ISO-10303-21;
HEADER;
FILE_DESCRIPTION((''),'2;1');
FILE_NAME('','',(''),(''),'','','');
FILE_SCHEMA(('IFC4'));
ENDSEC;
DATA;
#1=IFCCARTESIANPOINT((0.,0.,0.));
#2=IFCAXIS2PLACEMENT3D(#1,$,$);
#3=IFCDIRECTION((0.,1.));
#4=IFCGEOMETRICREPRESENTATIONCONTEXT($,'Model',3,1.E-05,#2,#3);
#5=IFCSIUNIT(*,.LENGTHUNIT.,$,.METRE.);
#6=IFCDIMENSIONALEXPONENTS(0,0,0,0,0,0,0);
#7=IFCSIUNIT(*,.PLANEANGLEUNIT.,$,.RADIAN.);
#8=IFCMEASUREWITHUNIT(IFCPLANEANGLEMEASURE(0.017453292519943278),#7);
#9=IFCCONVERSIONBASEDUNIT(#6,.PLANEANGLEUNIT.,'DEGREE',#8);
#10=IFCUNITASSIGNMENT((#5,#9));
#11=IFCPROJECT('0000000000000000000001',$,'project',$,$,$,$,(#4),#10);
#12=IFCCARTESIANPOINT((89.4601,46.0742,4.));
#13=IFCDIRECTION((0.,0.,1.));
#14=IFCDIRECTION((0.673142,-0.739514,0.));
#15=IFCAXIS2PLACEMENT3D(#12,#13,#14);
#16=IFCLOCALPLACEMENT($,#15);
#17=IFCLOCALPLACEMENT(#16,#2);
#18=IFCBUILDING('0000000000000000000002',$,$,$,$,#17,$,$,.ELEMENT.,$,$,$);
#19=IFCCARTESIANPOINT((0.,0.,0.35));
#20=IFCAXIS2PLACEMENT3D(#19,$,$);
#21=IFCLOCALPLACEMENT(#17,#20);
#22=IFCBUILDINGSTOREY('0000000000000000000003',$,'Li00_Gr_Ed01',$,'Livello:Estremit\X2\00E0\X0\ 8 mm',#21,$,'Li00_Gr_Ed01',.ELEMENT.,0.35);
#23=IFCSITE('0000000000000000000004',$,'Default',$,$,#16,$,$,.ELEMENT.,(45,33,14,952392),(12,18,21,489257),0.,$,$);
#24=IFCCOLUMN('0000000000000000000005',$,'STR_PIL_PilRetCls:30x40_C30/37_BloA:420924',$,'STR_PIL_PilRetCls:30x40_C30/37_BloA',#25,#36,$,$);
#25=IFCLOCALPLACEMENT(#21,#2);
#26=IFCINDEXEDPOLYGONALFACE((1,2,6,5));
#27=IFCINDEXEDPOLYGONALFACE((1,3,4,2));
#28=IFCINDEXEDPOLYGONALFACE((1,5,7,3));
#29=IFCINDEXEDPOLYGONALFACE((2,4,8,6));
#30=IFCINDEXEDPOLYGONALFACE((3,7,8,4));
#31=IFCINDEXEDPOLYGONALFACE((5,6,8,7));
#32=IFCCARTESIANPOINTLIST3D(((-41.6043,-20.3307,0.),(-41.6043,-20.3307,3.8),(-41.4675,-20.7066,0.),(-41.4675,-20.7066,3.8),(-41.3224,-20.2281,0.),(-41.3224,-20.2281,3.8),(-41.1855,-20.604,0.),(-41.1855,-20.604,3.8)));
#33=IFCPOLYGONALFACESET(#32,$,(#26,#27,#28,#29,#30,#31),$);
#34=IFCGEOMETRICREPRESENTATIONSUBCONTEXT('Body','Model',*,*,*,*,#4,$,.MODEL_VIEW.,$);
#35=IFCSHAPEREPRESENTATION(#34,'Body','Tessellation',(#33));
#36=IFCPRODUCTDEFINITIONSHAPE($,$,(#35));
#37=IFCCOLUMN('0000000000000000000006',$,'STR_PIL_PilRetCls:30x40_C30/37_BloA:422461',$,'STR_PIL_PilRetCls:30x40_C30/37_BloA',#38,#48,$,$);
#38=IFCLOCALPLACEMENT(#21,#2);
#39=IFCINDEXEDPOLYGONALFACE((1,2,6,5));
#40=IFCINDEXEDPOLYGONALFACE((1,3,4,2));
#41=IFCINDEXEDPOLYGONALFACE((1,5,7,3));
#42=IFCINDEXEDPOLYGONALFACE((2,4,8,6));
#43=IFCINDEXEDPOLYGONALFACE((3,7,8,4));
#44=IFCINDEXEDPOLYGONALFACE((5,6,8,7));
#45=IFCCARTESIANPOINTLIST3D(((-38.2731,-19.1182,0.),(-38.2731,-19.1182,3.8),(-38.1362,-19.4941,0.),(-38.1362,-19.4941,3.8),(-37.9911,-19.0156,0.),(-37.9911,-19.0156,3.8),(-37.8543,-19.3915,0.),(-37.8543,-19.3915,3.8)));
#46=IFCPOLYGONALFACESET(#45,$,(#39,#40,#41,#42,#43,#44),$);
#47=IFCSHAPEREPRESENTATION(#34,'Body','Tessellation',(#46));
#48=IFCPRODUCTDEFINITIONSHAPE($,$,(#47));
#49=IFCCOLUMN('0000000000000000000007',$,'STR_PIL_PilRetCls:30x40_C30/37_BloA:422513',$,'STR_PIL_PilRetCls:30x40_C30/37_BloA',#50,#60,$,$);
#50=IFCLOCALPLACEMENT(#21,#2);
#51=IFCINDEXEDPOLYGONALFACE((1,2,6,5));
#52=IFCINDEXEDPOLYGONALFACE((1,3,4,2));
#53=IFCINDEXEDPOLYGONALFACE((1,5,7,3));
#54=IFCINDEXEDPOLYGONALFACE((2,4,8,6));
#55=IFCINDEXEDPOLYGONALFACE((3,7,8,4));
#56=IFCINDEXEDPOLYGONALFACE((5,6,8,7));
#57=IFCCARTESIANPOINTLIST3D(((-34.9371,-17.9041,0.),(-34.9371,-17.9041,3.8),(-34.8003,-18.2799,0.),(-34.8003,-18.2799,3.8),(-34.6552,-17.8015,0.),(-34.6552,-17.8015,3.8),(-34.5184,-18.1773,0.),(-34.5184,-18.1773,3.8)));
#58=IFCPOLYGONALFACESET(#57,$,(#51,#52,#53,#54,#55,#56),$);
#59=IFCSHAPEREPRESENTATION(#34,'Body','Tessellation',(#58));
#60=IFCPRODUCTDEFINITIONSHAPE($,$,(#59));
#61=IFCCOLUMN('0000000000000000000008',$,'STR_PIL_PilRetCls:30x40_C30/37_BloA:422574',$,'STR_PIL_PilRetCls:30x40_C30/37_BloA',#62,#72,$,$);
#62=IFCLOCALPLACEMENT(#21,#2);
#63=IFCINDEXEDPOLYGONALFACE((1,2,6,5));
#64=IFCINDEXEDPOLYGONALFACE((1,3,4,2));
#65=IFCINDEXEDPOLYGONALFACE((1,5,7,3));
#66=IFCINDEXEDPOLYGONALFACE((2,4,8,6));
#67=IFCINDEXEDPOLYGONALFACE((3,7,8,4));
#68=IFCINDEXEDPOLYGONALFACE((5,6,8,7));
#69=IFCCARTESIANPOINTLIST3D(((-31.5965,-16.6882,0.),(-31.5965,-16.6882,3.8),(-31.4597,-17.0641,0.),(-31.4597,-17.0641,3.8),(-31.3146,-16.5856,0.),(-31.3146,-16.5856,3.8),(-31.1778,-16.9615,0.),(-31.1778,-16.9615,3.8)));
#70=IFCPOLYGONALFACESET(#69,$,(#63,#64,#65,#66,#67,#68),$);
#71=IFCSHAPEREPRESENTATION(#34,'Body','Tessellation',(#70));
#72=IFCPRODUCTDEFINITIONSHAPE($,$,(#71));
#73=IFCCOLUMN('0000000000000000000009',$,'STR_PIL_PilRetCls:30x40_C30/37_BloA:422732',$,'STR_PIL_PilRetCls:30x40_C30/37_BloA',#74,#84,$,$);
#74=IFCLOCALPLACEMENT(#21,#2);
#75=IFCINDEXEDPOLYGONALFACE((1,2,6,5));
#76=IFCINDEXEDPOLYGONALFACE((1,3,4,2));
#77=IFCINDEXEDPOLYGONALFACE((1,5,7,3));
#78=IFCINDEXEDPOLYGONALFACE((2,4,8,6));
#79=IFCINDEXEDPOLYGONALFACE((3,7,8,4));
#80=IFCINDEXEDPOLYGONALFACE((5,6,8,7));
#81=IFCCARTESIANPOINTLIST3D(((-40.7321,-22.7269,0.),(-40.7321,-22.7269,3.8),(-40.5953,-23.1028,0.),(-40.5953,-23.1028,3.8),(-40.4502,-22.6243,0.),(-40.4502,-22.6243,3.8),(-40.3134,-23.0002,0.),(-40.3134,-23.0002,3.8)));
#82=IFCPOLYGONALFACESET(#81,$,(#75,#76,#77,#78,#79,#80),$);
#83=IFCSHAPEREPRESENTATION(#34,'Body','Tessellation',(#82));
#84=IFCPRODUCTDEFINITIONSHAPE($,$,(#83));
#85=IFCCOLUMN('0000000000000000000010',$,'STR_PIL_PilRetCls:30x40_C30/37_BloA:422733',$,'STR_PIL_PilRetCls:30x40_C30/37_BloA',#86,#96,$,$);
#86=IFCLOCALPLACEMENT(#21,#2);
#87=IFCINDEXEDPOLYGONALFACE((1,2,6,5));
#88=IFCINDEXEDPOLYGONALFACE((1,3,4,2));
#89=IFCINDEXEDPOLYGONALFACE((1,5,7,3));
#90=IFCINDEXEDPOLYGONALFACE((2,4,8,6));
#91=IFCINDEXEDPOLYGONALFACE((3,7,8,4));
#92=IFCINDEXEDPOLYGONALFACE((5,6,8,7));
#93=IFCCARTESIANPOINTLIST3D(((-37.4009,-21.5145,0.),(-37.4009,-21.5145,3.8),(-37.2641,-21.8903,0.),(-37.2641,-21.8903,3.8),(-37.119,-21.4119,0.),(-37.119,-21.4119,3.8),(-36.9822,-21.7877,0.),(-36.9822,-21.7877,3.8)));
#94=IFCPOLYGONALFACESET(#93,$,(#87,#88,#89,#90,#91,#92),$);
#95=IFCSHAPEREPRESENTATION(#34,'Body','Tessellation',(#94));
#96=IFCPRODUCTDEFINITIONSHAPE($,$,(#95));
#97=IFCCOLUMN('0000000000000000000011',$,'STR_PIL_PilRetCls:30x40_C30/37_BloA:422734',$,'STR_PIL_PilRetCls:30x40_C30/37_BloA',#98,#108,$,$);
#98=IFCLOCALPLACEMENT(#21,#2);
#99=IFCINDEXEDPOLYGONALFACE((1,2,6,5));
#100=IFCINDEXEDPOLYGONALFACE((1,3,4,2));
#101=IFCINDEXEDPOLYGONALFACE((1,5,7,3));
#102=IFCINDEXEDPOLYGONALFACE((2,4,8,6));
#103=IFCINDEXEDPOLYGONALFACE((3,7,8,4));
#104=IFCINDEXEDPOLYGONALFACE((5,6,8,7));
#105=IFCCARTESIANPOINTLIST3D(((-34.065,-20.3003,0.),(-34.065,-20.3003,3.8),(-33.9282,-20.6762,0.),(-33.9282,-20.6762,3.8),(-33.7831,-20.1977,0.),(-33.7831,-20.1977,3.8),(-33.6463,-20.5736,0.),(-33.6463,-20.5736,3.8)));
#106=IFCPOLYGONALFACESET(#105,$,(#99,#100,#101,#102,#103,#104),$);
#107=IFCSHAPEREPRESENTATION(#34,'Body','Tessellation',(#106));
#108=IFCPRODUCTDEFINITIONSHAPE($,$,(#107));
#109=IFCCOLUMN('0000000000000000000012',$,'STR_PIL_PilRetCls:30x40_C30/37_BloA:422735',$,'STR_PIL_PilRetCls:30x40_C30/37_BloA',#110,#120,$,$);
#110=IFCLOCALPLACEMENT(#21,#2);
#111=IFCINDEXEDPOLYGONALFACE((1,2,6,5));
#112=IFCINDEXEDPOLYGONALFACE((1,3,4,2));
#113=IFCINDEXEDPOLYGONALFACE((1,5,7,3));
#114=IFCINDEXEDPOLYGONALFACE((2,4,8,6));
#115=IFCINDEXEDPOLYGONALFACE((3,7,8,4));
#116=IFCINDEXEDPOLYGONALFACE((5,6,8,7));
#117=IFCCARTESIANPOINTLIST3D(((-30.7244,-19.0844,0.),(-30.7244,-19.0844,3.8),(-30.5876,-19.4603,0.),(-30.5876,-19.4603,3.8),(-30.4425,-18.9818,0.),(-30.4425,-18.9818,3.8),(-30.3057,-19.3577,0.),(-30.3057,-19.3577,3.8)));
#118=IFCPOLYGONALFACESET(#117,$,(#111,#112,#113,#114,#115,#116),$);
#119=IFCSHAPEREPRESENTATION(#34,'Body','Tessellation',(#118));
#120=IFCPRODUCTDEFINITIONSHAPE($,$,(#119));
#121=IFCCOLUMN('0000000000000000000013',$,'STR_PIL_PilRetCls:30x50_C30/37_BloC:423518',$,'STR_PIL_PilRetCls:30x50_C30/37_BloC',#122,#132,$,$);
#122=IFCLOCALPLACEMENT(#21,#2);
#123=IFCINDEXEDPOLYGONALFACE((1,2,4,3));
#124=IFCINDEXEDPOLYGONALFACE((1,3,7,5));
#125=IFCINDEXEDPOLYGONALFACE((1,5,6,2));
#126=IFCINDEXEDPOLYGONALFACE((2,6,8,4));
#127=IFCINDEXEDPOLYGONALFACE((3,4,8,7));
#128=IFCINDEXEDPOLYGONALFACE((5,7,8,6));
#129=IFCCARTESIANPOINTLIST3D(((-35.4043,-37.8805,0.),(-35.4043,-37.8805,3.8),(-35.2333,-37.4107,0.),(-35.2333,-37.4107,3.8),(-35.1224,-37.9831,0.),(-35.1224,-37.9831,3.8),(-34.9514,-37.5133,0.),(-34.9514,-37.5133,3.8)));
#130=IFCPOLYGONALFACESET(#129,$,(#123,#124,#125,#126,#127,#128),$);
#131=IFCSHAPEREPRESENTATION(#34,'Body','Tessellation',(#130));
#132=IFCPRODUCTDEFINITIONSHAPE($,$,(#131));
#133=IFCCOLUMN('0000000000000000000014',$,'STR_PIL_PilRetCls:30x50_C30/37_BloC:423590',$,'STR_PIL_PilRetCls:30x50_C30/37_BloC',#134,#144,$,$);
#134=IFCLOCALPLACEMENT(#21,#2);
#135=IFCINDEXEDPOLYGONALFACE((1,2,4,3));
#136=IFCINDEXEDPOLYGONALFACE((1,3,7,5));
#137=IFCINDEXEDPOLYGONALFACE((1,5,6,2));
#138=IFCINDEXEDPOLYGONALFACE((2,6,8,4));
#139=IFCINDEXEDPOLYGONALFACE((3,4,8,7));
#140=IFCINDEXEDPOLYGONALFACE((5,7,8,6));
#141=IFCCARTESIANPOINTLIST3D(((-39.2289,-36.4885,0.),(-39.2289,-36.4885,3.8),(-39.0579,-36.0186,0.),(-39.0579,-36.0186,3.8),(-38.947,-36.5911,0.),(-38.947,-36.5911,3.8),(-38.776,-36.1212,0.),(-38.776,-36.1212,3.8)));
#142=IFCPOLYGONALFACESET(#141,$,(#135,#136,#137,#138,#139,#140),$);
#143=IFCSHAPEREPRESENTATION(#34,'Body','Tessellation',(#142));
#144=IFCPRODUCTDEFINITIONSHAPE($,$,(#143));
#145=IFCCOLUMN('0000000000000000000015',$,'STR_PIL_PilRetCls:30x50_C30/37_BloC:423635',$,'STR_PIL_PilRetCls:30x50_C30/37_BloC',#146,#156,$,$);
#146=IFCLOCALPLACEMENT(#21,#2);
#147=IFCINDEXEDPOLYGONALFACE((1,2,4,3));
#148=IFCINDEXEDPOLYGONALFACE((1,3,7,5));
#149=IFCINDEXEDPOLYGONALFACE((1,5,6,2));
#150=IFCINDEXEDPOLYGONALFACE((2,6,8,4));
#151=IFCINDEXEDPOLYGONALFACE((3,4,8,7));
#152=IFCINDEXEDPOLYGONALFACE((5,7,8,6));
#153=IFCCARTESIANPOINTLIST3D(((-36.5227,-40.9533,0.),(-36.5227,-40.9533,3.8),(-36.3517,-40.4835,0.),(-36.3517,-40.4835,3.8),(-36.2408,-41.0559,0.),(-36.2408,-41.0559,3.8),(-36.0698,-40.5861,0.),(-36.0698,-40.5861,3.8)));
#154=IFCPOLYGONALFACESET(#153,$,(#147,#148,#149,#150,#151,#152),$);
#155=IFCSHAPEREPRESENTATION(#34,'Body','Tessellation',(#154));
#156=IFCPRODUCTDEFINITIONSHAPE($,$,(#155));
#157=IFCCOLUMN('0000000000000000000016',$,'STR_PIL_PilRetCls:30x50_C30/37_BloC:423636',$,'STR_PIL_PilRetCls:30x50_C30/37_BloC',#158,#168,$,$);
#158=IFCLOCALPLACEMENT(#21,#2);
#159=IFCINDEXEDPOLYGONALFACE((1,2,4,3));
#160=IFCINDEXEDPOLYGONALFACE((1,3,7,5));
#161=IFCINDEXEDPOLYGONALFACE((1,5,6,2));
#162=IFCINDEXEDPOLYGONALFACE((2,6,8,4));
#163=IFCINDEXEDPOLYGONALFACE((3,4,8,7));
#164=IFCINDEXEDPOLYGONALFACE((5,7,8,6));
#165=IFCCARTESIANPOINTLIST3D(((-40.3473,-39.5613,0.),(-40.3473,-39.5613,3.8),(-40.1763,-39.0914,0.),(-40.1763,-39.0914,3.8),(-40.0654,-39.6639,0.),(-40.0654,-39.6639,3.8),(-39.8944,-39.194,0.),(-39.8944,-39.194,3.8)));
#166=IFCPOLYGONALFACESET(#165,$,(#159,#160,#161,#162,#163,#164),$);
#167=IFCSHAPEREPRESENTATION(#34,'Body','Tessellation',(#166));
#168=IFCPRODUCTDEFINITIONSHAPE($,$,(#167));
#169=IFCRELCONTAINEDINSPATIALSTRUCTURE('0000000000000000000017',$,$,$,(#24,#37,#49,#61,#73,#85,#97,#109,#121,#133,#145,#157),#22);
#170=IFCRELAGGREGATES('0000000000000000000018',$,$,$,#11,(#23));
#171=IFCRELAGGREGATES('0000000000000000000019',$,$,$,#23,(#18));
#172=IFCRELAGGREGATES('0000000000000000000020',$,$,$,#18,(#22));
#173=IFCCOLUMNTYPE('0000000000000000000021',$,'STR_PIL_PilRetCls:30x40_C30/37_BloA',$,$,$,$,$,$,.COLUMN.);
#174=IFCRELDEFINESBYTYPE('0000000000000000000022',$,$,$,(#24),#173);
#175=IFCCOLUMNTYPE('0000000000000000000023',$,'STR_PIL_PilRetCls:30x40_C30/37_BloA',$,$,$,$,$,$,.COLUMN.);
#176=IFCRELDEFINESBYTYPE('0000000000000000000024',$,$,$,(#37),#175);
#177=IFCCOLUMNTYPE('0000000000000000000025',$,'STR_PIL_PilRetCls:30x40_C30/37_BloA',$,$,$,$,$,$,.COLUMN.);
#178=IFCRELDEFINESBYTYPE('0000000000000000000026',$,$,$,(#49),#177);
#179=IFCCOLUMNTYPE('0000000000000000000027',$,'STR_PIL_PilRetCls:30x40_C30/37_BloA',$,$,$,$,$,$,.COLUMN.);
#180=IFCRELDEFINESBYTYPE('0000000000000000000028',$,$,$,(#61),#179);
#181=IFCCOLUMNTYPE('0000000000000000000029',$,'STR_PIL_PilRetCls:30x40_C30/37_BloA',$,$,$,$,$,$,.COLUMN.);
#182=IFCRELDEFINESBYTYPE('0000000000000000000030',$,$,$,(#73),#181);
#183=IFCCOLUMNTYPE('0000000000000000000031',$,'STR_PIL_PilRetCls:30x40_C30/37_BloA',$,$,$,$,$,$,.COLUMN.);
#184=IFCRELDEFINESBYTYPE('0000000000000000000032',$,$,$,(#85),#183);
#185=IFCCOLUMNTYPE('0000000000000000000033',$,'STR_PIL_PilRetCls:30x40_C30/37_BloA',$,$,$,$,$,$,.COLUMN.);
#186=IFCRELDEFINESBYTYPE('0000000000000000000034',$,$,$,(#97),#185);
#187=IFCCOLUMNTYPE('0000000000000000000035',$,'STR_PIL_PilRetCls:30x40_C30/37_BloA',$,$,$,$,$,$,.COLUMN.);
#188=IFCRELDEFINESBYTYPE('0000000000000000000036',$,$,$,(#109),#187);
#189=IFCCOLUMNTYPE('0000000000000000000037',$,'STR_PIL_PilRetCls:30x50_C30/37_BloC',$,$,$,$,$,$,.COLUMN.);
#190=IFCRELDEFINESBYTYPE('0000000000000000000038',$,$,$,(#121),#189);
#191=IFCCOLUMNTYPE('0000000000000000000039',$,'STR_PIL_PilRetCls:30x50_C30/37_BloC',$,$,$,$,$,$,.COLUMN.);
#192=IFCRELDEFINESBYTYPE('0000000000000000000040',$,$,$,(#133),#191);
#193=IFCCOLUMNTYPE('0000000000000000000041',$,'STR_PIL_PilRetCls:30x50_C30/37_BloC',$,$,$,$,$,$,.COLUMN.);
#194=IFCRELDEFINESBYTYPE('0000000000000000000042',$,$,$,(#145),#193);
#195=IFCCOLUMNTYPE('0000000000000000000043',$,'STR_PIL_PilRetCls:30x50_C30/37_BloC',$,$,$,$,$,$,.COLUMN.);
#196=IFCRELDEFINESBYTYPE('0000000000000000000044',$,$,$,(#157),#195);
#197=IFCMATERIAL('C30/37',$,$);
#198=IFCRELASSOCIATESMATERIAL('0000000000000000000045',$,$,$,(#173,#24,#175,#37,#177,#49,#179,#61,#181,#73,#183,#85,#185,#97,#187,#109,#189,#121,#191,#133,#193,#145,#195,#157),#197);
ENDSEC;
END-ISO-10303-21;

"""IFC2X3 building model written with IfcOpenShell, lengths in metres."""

from ifc_helpers import new_model, entity, si_unit, converted_unit, direction, frame, frame_2d, origin, place, context, subcontext, project, spatial, rectangle, extrude, source, transform, mapped, material, type_object, type_shapes, element, save


model = new_model("IFC2X3")

# Units and contexts
model_context = context("Model", 3, precision=1e-05, world=origin(), true_north=direction((0.0, 1.0)))
body_context = subcontext(model_context, "Body", "Model", "MODEL_VIEW")
ifc_project = project(units=[si_unit("LENGTHUNIT", "METRE"), converted_unit("PLANEANGLEUNIT", "DEGREE", entity("IfcPlaneAngleMeasure", 0.017453292519943278), si_unit("PLANEANGLEUNIT", "RADIAN"), dimensions=[0, 0, 0, 0, 0, 0, 0])], contexts=[model_context])

# Site, building, storey
site_placement = place(None, frame((89.4601, 46.0742, 4.0), z_axis=(0.0, 0.0, 1.0), x_axis=(0.673142, -0.739514, 0.0)))
site = spatial("IfcSite", under=ifc_project, at=site_placement, Name="Default", CompositionType="ELEMENT", RefLatitude=(45, 33, 14, 952392), RefLongitude=(12, 18, 21, 489257), RefElevation=0.0)
building_placement = place(site_placement, origin())
building = spatial("IfcBuilding", under=site, at=building_placement, CompositionType="ELEMENT")
storey_placement = place(building_placement, frame((0.0, 0.0, 0.35)))
storey = spatial("IfcBuildingStorey", under=building, at=storey_placement, Name="Li00_Gr_Ed01", ObjectType="Livello:Estremità 8 mm", LongName="Li00_Gr_Ed01", CompositionType="ELEMENT", Elevation=0.35)

# Columns
ifc_material_1 = material(Name="C30/37")
column_type_1 = type_object("IfcColumnType", Name="STR_PIL_PilRetCls:30x40_C30/37_BloA", PredefinedType="COLUMN", material=ifc_material_1)
shared_shape_1 = source(origin(), body_context, "Body", "SweptSolid", [
    extrude(rectangle(XDim=0.3, YDim=0.4, at=frame_2d((0.0, 0.0), x_axis=(1.0, 0.0))), frame((-41.3949, -20.4673, 0.35), z_axis=(0.0, 0.0, 1.0), x_axis=(0.939693, 0.34202, 0.0)), (0.0, 0.0, 1.0), 3.8),
])
type_shapes(column_type_1, [shared_shape_1])
column_1_placement = place(storey_placement, frame((0.0, 0.0, -0.35)))
element("IfcColumn", 1, at=column_1_placement, inside=storey, type_object=column_type_1, material=ifc_material_1, Name="STR_PIL_PilRetCls:30x40_C30/37_BloA:420924", ObjectType="STR_PIL_PilRetCls:30x40_C30/37_BloA", context=body_context, shape_type="MappedRepresentation", body=[
    mapped(shared_shape_1, transform((0.0, 0.0, 0.0), scale=1.0)),
])
column_type_2 = type_object("IfcColumnType", Name="STR_PIL_PilRetCls:30x40_C30/37_BloA", PredefinedType="COLUMN", material=ifc_material_1)
shared_shape_2 = source(origin(), body_context, "Body", "SweptSolid", [
    extrude(rectangle(XDim=0.3, YDim=0.4, at=frame_2d((0.0, 0.0), x_axis=(1.0, 0.0))), frame((-38.0637, -19.2549, 0.35), z_axis=(0.0, 0.0, 1.0), x_axis=(0.939693, 0.34202, 0.0)), (0.0, 0.0, 1.0), 3.8),
])
type_shapes(column_type_2, [shared_shape_2])
column_2_placement = place(storey_placement, frame((0.0, 0.0, -0.35)))
element("IfcColumn", 2, at=column_2_placement, inside=storey, type_object=column_type_2, material=ifc_material_1, Name="STR_PIL_PilRetCls:30x40_C30/37_BloA:422461", ObjectType="STR_PIL_PilRetCls:30x40_C30/37_BloA", context=body_context, shape_type="MappedRepresentation", body=[
    mapped(shared_shape_2, transform((0.0, 0.0, 0.0), scale=1.0)),
])
column_type_3 = type_object("IfcColumnType", Name="STR_PIL_PilRetCls:30x40_C30/37_BloA", PredefinedType="COLUMN", material=ifc_material_1)
shared_shape_3 = source(origin(), body_context, "Body", "SweptSolid", [
    extrude(rectangle(XDim=0.3, YDim=0.4, at=frame_2d((0.0, 0.0), x_axis=(1.0, 0.0))), frame((-34.7278, -18.0407, 0.35), z_axis=(0.0, 0.0, 1.0), x_axis=(0.939693, 0.34202, 0.0)), (0.0, 0.0, 1.0), 3.8),
])
type_shapes(column_type_3, [shared_shape_3])
column_3_placement = place(storey_placement, frame((0.0, 0.0, -0.35)))
element("IfcColumn", 3, at=column_3_placement, inside=storey, type_object=column_type_3, material=ifc_material_1, Name="STR_PIL_PilRetCls:30x40_C30/37_BloA:422513", ObjectType="STR_PIL_PilRetCls:30x40_C30/37_BloA", context=body_context, shape_type="MappedRepresentation", body=[
    mapped(shared_shape_3, transform((0.0, 0.0, 0.0), scale=1.0)),
])
column_type_4 = type_object("IfcColumnType", Name="STR_PIL_PilRetCls:30x40_C30/37_BloA", PredefinedType="COLUMN", material=ifc_material_1)
shared_shape_4 = source(origin(), body_context, "Body", "SweptSolid", [
    extrude(rectangle(XDim=0.3, YDim=0.4, at=frame_2d((0.0, 0.0), x_axis=(1.0, 0.0))), frame((-31.3872, -16.8248, 0.35), z_axis=(0.0, 0.0, 1.0), x_axis=(0.939693, 0.34202, 0.0)), (0.0, 0.0, 1.0), 3.8),
])
type_shapes(column_type_4, [shared_shape_4])
column_4_placement = place(storey_placement, frame((0.0, 0.0, -0.35)))
element("IfcColumn", 4, at=column_4_placement, inside=storey, type_object=column_type_4, material=ifc_material_1, Name="STR_PIL_PilRetCls:30x40_C30/37_BloA:422574", ObjectType="STR_PIL_PilRetCls:30x40_C30/37_BloA", context=body_context, shape_type="MappedRepresentation", body=[
    mapped(shared_shape_4, transform((0.0, 0.0, 0.0), scale=1.0)),
])
column_type_5 = type_object("IfcColumnType", Name="STR_PIL_PilRetCls:30x40_C30/37_BloA", PredefinedType="COLUMN", material=ifc_material_1)
shared_shape_5 = source(origin(), body_context, "Body", "SweptSolid", [
    extrude(rectangle(XDim=0.3, YDim=0.4, at=frame_2d((0.0, 0.0), x_axis=(1.0, 0.0))), frame((-40.5228, -22.8636, 0.35), z_axis=(0.0, 0.0, 1.0), x_axis=(0.939693, 0.34202, 0.0)), (0.0, 0.0, 1.0), 3.8),
])
type_shapes(column_type_5, [shared_shape_5])
column_5_placement = place(storey_placement, frame((0.0, 0.0, -0.35)))
element("IfcColumn", 5, at=column_5_placement, inside=storey, type_object=column_type_5, material=ifc_material_1, Name="STR_PIL_PilRetCls:30x40_C30/37_BloA:422732", ObjectType="STR_PIL_PilRetCls:30x40_C30/37_BloA", context=body_context, shape_type="MappedRepresentation", body=[
    mapped(shared_shape_5, transform((0.0, 0.0, 0.0), scale=1.0)),
])
column_type_6 = type_object("IfcColumnType", Name="STR_PIL_PilRetCls:30x40_C30/37_BloA", PredefinedType="COLUMN", material=ifc_material_1)
shared_shape_6 = source(origin(), body_context, "Body", "SweptSolid", [
    extrude(rectangle(XDim=0.3, YDim=0.4, at=frame_2d((0.0, 0.0), x_axis=(1.0, 0.0))), frame((-37.1915, -21.6511, 0.35), z_axis=(0.0, 0.0, 1.0), x_axis=(0.939693, 0.34202, 0.0)), (0.0, 0.0, 1.0), 3.8),
])
type_shapes(column_type_6, [shared_shape_6])
column_6_placement = place(storey_placement, frame((0.0, 0.0, -0.35)))
element("IfcColumn", 6, at=column_6_placement, inside=storey, type_object=column_type_6, material=ifc_material_1, Name="STR_PIL_PilRetCls:30x40_C30/37_BloA:422733", ObjectType="STR_PIL_PilRetCls:30x40_C30/37_BloA", context=body_context, shape_type="MappedRepresentation", body=[
    mapped(shared_shape_6, transform((0.0, 0.0, 0.0), scale=1.0)),
])
column_type_7 = type_object("IfcColumnType", Name="STR_PIL_PilRetCls:30x40_C30/37_BloA", PredefinedType="COLUMN", material=ifc_material_1)
shared_shape_7 = source(origin(), body_context, "Body", "SweptSolid", [
    extrude(rectangle(XDim=0.3, YDim=0.4, at=frame_2d((0.0, 0.0), x_axis=(1.0, 0.0))), frame((-33.8556, -20.4369, 0.35), z_axis=(0.0, 0.0, 1.0), x_axis=(0.939693, 0.34202, 0.0)), (0.0, 0.0, 1.0), 3.8),
])
type_shapes(column_type_7, [shared_shape_7])
column_7_placement = place(storey_placement, frame((0.0, 0.0, -0.35)))
element("IfcColumn", 7, at=column_7_placement, inside=storey, type_object=column_type_7, material=ifc_material_1, Name="STR_PIL_PilRetCls:30x40_C30/37_BloA:422734", ObjectType="STR_PIL_PilRetCls:30x40_C30/37_BloA", context=body_context, shape_type="MappedRepresentation", body=[
    mapped(shared_shape_7, transform((0.0, 0.0, 0.0), scale=1.0)),
])
column_type_8 = type_object("IfcColumnType", Name="STR_PIL_PilRetCls:30x40_C30/37_BloA", PredefinedType="COLUMN", material=ifc_material_1)
shared_shape_8 = source(origin(), body_context, "Body", "SweptSolid", [
    extrude(rectangle(XDim=0.3, YDim=0.4, at=frame_2d((0.0, 0.0), x_axis=(1.0, 0.0))), frame((-30.515, -19.221, 0.35), z_axis=(0.0, 0.0, 1.0), x_axis=(0.939693, 0.34202, 0.0)), (0.0, 0.0, 1.0), 3.8),
])
type_shapes(column_type_8, [shared_shape_8])
column_8_placement = place(storey_placement, frame((0.0, 0.0, -0.35)))
element("IfcColumn", 8, at=column_8_placement, inside=storey, type_object=column_type_8, material=ifc_material_1, Name="STR_PIL_PilRetCls:30x40_C30/37_BloA:422735", ObjectType="STR_PIL_PilRetCls:30x40_C30/37_BloA", context=body_context, shape_type="MappedRepresentation", body=[
    mapped(shared_shape_8, transform((0.0, 0.0, 0.0), scale=1.0)),
])
column_type_9 = type_object("IfcColumnType", Name="STR_PIL_PilRetCls:30x50_C30/37_BloC", PredefinedType="COLUMN", material=ifc_material_1)
shared_shape_9 = source(origin(), body_context, "Body", "SweptSolid", [
    extrude(rectangle(XDim=0.3, YDim=0.5, at=frame_2d((0.0, 0.0), x_axis=(1.0, 0.0))), frame((-35.1779, -37.6969, 0.35), z_axis=(0.0, 0.0, 1.0), x_axis=(-0.939693, 0.34202, 0.0)), (0.0, 0.0, 1.0), 3.8),
])
type_shapes(column_type_9, [shared_shape_9])
column_9_placement = place(storey_placement, frame((0.0, 0.0, -0.35)))
element("IfcColumn", 9, at=column_9_placement, inside=storey, type_object=column_type_9, material=ifc_material_1, Name="STR_PIL_PilRetCls:30x50_C30/37_BloC:423518", ObjectType="STR_PIL_PilRetCls:30x50_C30/37_BloC", context=body_context, shape_type="MappedRepresentation", body=[
    mapped(shared_shape_9, transform((0.0, 0.0, 0.0), scale=1.0)),
])
column_type_10 = type_object("IfcColumnType", Name="STR_PIL_PilRetCls:30x50_C30/37_BloC", PredefinedType="COLUMN", material=ifc_material_1)
shared_shape_10 = source(origin(), body_context, "Body", "SweptSolid", [
    extrude(rectangle(XDim=0.3, YDim=0.5, at=frame_2d((0.0, 0.0), x_axis=(1.0, 0.0))), frame((-39.0024, -36.3049, 0.35), z_axis=(0.0, 0.0, 1.0), x_axis=(-0.939693, 0.34202, 0.0)), (0.0, 0.0, 1.0), 3.8),
])
type_shapes(column_type_10, [shared_shape_10])
column_10_placement = place(storey_placement, frame((0.0, 0.0, -0.35)))
element("IfcColumn", 10, at=column_10_placement, inside=storey, type_object=column_type_10, material=ifc_material_1, Name="STR_PIL_PilRetCls:30x50_C30/37_BloC:423590", ObjectType="STR_PIL_PilRetCls:30x50_C30/37_BloC", context=body_context, shape_type="MappedRepresentation", body=[
    mapped(shared_shape_10, transform((0.0, 0.0, 0.0), scale=1.0)),
])
column_type_11 = type_object("IfcColumnType", Name="STR_PIL_PilRetCls:30x50_C30/37_BloC", PredefinedType="COLUMN", material=ifc_material_1)
shared_shape_11 = source(origin(), body_context, "Body", "SweptSolid", [
    extrude(rectangle(XDim=0.3, YDim=0.5, at=frame_2d((0.0, 0.0), x_axis=(1.0, 0.0))), frame((-36.2963, -40.7697, 0.35), z_axis=(0.0, 0.0, 1.0), x_axis=(-0.939693, 0.34202, 0.0)), (0.0, 0.0, 1.0), 3.8),
])
type_shapes(column_type_11, [shared_shape_11])
column_11_placement = place(storey_placement, frame((0.0, 0.0, -0.35)))
element("IfcColumn", 11, at=column_11_placement, inside=storey, type_object=column_type_11, material=ifc_material_1, Name="STR_PIL_PilRetCls:30x50_C30/37_BloC:423635", ObjectType="STR_PIL_PilRetCls:30x50_C30/37_BloC", context=body_context, shape_type="MappedRepresentation", body=[
    mapped(shared_shape_11, transform((0.0, 0.0, 0.0), scale=1.0)),
])
column_type_12 = type_object("IfcColumnType", Name="STR_PIL_PilRetCls:30x50_C30/37_BloC", PredefinedType="COLUMN", material=ifc_material_1)
shared_shape_12 = source(origin(), body_context, "Body", "SweptSolid", [
    extrude(rectangle(XDim=0.3, YDim=0.5, at=frame_2d((0.0, 0.0), x_axis=(1.0, 0.0))), frame((-40.1208, -39.3777, 0.35), z_axis=(0.0, 0.0, 1.0), x_axis=(-0.939693, 0.34202, 0.0)), (0.0, 0.0, 1.0), 3.8),
])
type_shapes(column_type_12, [shared_shape_12])
column_12_placement = place(storey_placement, frame((0.0, 0.0, -0.35)))
element("IfcColumn", 12, at=column_12_placement, inside=storey, type_object=column_type_12, material=ifc_material_1, Name="STR_PIL_PilRetCls:30x50_C30/37_BloC:423636", ObjectType="STR_PIL_PilRetCls:30x50_C30/37_BloC", context=body_context, shape_type="MappedRepresentation", body=[
    mapped(shared_shape_12, transform((0.0, 0.0, 0.0), scale=1.0)),
])

save(model, "model.ifc")
